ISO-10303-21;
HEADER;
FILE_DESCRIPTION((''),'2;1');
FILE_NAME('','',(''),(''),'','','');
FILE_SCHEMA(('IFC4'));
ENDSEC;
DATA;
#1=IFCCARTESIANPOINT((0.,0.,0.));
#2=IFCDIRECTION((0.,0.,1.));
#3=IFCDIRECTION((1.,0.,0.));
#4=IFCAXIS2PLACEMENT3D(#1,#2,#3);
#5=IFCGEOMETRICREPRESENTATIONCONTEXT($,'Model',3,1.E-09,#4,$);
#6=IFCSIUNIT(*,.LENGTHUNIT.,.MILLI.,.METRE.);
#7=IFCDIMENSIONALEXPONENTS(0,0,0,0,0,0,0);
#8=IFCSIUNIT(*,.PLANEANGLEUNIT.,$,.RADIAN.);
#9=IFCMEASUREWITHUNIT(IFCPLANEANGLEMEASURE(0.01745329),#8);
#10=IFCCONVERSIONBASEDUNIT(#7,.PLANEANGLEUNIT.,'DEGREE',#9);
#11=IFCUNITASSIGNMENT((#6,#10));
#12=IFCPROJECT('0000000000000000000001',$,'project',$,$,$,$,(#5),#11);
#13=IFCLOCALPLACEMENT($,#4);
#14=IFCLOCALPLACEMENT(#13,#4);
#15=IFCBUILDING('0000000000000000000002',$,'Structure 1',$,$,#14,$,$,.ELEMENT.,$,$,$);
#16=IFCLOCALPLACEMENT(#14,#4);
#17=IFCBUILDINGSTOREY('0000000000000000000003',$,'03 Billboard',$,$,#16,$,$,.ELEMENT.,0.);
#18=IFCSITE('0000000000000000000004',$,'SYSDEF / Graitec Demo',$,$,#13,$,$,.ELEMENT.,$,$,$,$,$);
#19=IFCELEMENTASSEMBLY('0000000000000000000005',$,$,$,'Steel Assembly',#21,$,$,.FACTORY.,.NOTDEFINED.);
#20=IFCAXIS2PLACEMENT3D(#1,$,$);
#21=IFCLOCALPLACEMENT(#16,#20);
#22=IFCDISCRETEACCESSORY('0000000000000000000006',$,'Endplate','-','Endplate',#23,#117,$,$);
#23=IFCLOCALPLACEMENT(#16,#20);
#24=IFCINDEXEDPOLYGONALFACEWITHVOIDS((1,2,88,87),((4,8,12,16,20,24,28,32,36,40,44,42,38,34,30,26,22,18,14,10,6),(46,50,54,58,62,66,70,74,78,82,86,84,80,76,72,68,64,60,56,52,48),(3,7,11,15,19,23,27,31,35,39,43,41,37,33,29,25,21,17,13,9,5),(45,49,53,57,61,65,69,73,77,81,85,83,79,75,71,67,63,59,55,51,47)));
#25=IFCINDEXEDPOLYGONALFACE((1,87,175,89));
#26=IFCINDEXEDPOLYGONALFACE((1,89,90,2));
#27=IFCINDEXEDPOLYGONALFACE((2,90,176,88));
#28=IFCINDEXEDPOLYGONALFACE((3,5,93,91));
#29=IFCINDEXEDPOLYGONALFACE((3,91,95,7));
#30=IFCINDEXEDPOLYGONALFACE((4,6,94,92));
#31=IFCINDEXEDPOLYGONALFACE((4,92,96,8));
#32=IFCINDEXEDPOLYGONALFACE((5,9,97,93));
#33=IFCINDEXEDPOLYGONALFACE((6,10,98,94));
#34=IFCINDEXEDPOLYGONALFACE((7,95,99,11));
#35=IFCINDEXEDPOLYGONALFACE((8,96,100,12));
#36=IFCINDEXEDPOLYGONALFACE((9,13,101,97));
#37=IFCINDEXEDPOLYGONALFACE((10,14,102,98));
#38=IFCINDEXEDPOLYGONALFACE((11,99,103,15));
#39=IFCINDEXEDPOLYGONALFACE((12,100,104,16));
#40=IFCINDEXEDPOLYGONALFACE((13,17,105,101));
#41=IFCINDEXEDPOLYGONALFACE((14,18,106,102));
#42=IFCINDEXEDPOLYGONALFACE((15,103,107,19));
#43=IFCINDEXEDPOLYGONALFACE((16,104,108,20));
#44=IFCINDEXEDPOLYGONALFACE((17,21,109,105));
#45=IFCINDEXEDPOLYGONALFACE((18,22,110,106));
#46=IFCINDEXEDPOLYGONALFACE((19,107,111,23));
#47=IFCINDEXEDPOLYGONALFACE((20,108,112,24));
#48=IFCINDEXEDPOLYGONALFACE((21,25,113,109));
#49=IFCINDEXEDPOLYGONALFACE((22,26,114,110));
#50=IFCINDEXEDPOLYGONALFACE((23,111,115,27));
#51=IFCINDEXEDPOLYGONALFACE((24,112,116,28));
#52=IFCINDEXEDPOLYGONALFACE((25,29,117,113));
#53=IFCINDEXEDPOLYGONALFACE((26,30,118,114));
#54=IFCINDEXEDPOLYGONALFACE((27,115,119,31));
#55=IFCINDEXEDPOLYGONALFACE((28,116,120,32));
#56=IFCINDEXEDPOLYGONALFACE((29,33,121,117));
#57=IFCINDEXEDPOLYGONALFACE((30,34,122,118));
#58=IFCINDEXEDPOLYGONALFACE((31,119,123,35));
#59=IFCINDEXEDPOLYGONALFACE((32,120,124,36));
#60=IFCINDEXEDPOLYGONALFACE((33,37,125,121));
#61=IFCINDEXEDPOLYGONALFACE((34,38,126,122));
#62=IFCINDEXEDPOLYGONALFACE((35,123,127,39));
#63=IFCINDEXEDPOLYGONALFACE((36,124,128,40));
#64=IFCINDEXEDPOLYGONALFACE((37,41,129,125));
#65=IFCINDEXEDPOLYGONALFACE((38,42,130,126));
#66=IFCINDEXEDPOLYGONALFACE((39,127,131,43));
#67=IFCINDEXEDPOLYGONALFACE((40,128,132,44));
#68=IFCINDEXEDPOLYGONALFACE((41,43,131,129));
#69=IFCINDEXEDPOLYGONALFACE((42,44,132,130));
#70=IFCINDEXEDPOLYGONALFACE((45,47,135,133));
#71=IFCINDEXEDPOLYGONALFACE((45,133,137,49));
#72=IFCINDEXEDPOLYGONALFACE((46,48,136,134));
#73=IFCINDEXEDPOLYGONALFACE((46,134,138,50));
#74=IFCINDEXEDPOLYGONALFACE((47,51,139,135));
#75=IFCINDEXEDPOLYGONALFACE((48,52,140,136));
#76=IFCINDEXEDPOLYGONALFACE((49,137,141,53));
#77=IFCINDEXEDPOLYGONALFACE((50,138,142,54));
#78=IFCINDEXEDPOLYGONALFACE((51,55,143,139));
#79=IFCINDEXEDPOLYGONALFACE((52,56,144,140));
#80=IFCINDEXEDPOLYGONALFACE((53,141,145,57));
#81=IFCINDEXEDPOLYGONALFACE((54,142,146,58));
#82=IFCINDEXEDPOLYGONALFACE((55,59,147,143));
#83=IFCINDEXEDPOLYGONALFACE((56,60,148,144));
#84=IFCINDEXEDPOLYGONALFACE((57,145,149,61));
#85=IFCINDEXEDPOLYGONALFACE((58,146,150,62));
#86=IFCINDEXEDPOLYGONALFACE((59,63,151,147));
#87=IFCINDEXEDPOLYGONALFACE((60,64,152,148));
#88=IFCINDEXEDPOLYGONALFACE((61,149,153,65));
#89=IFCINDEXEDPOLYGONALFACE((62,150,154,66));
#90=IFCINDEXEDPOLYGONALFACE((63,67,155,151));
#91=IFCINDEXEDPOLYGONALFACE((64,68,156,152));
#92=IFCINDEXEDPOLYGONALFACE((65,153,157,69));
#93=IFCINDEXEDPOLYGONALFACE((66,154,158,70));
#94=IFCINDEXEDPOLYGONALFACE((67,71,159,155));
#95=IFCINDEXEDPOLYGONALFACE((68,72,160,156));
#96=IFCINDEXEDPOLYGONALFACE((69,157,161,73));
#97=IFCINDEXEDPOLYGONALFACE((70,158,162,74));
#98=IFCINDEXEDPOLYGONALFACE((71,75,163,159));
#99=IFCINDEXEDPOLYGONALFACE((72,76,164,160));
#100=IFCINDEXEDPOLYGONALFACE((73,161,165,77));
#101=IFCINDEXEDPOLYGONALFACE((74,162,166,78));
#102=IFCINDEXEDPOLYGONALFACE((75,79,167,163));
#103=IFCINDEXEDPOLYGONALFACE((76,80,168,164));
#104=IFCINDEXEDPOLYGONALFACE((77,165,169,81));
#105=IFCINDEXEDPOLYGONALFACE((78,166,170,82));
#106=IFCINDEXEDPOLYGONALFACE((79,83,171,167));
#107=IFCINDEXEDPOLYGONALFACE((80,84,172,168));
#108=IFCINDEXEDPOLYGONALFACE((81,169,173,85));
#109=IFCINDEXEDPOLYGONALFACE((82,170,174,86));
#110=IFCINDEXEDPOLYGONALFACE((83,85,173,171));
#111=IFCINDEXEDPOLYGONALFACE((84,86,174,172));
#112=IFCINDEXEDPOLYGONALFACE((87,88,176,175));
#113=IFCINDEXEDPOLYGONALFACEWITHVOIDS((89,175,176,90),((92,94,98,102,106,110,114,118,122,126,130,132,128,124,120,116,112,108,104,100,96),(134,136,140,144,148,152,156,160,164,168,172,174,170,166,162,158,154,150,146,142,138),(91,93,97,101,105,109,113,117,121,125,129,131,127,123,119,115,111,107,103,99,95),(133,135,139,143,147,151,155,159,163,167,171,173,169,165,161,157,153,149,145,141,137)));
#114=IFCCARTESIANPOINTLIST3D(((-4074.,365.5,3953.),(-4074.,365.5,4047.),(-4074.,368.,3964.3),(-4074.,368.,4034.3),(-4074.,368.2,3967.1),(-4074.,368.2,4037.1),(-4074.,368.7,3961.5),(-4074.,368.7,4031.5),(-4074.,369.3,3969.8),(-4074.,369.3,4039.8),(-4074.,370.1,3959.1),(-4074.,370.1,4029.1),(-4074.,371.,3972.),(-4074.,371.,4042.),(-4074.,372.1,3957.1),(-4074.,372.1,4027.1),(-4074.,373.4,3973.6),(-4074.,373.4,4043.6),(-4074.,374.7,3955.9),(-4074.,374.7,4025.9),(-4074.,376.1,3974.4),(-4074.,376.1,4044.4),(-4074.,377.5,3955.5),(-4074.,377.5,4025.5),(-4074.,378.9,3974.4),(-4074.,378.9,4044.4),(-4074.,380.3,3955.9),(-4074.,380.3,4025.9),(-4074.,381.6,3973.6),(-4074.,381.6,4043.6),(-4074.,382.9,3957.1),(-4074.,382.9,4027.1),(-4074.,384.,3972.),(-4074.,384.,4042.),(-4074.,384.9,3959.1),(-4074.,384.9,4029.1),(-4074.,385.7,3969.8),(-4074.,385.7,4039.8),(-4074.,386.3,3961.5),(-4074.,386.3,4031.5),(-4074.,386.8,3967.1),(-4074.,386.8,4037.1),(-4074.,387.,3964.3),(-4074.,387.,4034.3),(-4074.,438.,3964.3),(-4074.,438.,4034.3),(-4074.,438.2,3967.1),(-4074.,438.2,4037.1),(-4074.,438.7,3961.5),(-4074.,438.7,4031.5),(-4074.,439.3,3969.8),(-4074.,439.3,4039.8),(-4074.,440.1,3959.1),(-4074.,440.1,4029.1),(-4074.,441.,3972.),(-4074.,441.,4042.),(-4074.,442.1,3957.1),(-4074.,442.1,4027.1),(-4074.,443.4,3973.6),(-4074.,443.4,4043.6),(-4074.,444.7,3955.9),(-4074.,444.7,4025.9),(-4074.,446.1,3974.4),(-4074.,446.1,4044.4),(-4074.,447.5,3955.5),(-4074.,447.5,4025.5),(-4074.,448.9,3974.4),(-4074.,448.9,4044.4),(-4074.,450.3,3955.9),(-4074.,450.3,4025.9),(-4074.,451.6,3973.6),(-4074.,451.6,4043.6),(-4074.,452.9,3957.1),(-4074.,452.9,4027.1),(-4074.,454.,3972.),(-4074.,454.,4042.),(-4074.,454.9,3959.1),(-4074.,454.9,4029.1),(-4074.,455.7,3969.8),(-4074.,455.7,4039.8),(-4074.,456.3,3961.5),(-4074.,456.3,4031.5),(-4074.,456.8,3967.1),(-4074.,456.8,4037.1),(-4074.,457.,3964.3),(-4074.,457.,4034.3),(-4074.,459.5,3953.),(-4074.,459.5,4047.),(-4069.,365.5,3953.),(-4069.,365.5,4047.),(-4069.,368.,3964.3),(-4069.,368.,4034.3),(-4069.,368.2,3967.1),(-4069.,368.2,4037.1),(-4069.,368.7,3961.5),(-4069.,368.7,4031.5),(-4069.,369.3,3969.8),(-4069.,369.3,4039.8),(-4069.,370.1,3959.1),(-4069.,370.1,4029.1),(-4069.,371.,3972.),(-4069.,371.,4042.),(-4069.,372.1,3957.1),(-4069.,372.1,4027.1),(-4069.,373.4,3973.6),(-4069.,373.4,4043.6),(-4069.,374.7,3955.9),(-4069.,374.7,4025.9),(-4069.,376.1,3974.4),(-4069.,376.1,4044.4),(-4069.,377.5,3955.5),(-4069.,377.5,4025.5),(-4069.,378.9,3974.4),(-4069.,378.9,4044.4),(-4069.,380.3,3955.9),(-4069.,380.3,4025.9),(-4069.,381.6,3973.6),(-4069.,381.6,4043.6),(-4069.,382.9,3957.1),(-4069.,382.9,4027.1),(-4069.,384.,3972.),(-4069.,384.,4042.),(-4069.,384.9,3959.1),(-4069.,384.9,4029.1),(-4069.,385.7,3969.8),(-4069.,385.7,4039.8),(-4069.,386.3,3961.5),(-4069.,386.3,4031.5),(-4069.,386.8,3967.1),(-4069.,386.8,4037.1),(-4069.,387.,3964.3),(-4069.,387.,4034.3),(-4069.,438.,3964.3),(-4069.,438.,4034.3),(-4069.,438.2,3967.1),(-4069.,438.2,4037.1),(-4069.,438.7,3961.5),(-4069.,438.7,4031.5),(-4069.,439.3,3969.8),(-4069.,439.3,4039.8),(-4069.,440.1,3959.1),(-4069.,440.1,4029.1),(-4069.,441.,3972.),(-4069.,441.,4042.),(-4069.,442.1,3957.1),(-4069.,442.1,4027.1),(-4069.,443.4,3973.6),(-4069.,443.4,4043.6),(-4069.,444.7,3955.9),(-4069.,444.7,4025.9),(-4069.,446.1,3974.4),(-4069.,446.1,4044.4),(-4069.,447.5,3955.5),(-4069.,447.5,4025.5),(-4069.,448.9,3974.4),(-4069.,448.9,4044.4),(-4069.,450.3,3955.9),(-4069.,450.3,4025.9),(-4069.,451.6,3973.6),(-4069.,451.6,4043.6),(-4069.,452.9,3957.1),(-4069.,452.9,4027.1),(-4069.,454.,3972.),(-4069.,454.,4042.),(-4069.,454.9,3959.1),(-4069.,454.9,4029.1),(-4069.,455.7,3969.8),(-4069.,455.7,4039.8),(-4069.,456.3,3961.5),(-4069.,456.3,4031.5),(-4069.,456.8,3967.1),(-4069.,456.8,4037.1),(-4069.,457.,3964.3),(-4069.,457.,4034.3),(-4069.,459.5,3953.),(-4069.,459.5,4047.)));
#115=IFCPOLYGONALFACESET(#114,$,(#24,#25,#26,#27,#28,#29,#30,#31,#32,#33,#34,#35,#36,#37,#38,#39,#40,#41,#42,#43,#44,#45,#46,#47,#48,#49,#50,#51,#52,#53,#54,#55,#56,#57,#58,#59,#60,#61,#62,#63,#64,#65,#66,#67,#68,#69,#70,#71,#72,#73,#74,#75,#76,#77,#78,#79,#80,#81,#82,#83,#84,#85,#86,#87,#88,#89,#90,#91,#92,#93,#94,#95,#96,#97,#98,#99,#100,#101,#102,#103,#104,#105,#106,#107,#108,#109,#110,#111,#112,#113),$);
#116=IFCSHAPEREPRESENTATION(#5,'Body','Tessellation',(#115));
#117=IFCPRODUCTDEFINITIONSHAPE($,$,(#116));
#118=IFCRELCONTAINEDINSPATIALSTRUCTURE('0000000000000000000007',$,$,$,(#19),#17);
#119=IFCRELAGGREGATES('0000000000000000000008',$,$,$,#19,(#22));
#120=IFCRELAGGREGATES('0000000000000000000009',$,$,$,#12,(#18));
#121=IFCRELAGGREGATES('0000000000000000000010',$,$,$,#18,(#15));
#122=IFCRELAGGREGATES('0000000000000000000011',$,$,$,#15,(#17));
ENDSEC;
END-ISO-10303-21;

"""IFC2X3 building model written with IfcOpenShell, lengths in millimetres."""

from ifc_helpers import new_model, entity, si_unit, converted_unit, frame, frame_2d, origin, origin_with_axes, place, context, project, spatial, polyline, circle, outline, extrude, element, aggregate, save


model = new_model("IFC2X3")

# Units and contexts
model_context = context("Model", 3, precision=1e-09, world=origin_with_axes())
ifc_project = project(units=[si_unit("LENGTHUNIT", "METRE", prefix="MILLI"), converted_unit("PLANEANGLEUNIT", "DEGREE", entity("IfcPlaneAngleMeasure", 0.01745329), si_unit("PLANEANGLEUNIT", "RADIAN"), dimensions=[0, 0, 0, 0, 0, 0, 0])], contexts=[model_context])

# Site, building, storey
site_placement = place(None, origin_with_axes())
site = spatial("IfcSite", under=ifc_project, at=site_placement, Name="SYSDEF / Graitec Demo", CompositionType="ELEMENT")
building_placement = place(site_placement, origin_with_axes())
building = spatial("IfcBuilding", under=site, at=building_placement, Name="Structure 1", CompositionType="ELEMENT")
storey_placement = place(building_placement, origin_with_axes())
storey = spatial("IfcBuildingStorey", under=building, at=storey_placement, Name="03 Billboard", CompositionType="ELEMENT", Elevation=0.0)

# Element assembly, discrete accessory, openings
assembly_1_placement = place(None, frame((-4239.1, -387.5, 4000.0), z_axis=(-1.0, 0.0, 0.0), x_axis=(0.0, 0.0, 1.0)))
assembly_1 = element("IfcElementAssembly", 1, at=assembly_1_placement, inside=storey, ObjectType="Steel Assembly", AssemblyPlace="FACTORY", PredefinedType="NOTDEFINED")
discrete_accessory_1_placement = place(assembly_1_placement, frame((47.0, 753.0, -170.1), z_axis=(0.0, 0.0, 1.0), x_axis=(0.0, 1.0, 0.0)))
discrete_accessory_1 = element("IfcDiscreteAccessory", 2, at=discrete_accessory_1_placement, Name="Endplate", Description="-", ObjectType="Endplate", context=model_context, shape_type="SweptSolid", body=[
    extrude(outline(polyline([(0.0, 0.0), (94.0, 0.0), (94.0, 94.0), (0.0, 94.0), (0.0, 0.0)])), origin_with_axes(), (0.0, 0.0, 1.0), 5.0),
])
opening_1_placement = place(discrete_accessory_1_placement, frame((47.0, 47.0, 5.5), z_axis=(0.0, 0.0, -1.0), x_axis=(0.0, 1.0, 0.0)))
element("IfcOpeningElement", 3, at=opening_1_placement, cuts=discrete_accessory_1, ObjectType="Opening", context=model_context, shape_type="SweptSolid", body=[
    extrude(circle(Radius=9.5, at=frame_2d((35.0, 35.0), x_axis=(1.0, 0.0))), origin(), (0.0, 0.0, 1.0), 6.0),
])
opening_2_placement = place(discrete_accessory_1_placement, frame((47.0, 47.0, 5.5), z_axis=(0.0, 0.0, -1.0), x_axis=(0.0, 1.0, 0.0)))
element("IfcOpeningElement", 4, at=opening_2_placement, cuts=discrete_accessory_1, ObjectType="Opening", context=model_context, shape_type="SweptSolid", body=[
    extrude(circle(Radius=9.5, at=frame_2d((-35.0, 35.0), x_axis=(1.0, 0.0))), origin(), (0.0, 0.0, 1.0), 6.0),
])
opening_3_placement = place(discrete_accessory_1_placement, frame((47.0, 47.0, 5.5), z_axis=(0.0, 0.0, -1.0), x_axis=(0.0, 1.0, 0.0)))
element("IfcOpeningElement", 5, at=opening_3_placement, cuts=discrete_accessory_1, ObjectType="Opening", context=model_context, shape_type="SweptSolid", body=[
    extrude(circle(Radius=9.5, at=frame_2d((35.0, -35.0), x_axis=(1.0, 0.0))), origin(), (0.0, 0.0, 1.0), 6.0),
])
opening_4_placement = place(discrete_accessory_1_placement, frame((47.0, 47.0, 5.5), z_axis=(0.0, 0.0, -1.0), x_axis=(0.0, 1.0, 0.0)))
element("IfcOpeningElement", 6, at=opening_4_placement, cuts=discrete_accessory_1, ObjectType="Opening", context=model_context, shape_type="SweptSolid", body=[
    extrude(circle(Radius=9.5, at=frame_2d((-35.0, -35.0), x_axis=(1.0, 0.0))), origin(), (0.0, 0.0, 1.0), 6.0),
])
aggregate(assembly_1, [discrete_accessory_1])

save(model, "model.ifc")
